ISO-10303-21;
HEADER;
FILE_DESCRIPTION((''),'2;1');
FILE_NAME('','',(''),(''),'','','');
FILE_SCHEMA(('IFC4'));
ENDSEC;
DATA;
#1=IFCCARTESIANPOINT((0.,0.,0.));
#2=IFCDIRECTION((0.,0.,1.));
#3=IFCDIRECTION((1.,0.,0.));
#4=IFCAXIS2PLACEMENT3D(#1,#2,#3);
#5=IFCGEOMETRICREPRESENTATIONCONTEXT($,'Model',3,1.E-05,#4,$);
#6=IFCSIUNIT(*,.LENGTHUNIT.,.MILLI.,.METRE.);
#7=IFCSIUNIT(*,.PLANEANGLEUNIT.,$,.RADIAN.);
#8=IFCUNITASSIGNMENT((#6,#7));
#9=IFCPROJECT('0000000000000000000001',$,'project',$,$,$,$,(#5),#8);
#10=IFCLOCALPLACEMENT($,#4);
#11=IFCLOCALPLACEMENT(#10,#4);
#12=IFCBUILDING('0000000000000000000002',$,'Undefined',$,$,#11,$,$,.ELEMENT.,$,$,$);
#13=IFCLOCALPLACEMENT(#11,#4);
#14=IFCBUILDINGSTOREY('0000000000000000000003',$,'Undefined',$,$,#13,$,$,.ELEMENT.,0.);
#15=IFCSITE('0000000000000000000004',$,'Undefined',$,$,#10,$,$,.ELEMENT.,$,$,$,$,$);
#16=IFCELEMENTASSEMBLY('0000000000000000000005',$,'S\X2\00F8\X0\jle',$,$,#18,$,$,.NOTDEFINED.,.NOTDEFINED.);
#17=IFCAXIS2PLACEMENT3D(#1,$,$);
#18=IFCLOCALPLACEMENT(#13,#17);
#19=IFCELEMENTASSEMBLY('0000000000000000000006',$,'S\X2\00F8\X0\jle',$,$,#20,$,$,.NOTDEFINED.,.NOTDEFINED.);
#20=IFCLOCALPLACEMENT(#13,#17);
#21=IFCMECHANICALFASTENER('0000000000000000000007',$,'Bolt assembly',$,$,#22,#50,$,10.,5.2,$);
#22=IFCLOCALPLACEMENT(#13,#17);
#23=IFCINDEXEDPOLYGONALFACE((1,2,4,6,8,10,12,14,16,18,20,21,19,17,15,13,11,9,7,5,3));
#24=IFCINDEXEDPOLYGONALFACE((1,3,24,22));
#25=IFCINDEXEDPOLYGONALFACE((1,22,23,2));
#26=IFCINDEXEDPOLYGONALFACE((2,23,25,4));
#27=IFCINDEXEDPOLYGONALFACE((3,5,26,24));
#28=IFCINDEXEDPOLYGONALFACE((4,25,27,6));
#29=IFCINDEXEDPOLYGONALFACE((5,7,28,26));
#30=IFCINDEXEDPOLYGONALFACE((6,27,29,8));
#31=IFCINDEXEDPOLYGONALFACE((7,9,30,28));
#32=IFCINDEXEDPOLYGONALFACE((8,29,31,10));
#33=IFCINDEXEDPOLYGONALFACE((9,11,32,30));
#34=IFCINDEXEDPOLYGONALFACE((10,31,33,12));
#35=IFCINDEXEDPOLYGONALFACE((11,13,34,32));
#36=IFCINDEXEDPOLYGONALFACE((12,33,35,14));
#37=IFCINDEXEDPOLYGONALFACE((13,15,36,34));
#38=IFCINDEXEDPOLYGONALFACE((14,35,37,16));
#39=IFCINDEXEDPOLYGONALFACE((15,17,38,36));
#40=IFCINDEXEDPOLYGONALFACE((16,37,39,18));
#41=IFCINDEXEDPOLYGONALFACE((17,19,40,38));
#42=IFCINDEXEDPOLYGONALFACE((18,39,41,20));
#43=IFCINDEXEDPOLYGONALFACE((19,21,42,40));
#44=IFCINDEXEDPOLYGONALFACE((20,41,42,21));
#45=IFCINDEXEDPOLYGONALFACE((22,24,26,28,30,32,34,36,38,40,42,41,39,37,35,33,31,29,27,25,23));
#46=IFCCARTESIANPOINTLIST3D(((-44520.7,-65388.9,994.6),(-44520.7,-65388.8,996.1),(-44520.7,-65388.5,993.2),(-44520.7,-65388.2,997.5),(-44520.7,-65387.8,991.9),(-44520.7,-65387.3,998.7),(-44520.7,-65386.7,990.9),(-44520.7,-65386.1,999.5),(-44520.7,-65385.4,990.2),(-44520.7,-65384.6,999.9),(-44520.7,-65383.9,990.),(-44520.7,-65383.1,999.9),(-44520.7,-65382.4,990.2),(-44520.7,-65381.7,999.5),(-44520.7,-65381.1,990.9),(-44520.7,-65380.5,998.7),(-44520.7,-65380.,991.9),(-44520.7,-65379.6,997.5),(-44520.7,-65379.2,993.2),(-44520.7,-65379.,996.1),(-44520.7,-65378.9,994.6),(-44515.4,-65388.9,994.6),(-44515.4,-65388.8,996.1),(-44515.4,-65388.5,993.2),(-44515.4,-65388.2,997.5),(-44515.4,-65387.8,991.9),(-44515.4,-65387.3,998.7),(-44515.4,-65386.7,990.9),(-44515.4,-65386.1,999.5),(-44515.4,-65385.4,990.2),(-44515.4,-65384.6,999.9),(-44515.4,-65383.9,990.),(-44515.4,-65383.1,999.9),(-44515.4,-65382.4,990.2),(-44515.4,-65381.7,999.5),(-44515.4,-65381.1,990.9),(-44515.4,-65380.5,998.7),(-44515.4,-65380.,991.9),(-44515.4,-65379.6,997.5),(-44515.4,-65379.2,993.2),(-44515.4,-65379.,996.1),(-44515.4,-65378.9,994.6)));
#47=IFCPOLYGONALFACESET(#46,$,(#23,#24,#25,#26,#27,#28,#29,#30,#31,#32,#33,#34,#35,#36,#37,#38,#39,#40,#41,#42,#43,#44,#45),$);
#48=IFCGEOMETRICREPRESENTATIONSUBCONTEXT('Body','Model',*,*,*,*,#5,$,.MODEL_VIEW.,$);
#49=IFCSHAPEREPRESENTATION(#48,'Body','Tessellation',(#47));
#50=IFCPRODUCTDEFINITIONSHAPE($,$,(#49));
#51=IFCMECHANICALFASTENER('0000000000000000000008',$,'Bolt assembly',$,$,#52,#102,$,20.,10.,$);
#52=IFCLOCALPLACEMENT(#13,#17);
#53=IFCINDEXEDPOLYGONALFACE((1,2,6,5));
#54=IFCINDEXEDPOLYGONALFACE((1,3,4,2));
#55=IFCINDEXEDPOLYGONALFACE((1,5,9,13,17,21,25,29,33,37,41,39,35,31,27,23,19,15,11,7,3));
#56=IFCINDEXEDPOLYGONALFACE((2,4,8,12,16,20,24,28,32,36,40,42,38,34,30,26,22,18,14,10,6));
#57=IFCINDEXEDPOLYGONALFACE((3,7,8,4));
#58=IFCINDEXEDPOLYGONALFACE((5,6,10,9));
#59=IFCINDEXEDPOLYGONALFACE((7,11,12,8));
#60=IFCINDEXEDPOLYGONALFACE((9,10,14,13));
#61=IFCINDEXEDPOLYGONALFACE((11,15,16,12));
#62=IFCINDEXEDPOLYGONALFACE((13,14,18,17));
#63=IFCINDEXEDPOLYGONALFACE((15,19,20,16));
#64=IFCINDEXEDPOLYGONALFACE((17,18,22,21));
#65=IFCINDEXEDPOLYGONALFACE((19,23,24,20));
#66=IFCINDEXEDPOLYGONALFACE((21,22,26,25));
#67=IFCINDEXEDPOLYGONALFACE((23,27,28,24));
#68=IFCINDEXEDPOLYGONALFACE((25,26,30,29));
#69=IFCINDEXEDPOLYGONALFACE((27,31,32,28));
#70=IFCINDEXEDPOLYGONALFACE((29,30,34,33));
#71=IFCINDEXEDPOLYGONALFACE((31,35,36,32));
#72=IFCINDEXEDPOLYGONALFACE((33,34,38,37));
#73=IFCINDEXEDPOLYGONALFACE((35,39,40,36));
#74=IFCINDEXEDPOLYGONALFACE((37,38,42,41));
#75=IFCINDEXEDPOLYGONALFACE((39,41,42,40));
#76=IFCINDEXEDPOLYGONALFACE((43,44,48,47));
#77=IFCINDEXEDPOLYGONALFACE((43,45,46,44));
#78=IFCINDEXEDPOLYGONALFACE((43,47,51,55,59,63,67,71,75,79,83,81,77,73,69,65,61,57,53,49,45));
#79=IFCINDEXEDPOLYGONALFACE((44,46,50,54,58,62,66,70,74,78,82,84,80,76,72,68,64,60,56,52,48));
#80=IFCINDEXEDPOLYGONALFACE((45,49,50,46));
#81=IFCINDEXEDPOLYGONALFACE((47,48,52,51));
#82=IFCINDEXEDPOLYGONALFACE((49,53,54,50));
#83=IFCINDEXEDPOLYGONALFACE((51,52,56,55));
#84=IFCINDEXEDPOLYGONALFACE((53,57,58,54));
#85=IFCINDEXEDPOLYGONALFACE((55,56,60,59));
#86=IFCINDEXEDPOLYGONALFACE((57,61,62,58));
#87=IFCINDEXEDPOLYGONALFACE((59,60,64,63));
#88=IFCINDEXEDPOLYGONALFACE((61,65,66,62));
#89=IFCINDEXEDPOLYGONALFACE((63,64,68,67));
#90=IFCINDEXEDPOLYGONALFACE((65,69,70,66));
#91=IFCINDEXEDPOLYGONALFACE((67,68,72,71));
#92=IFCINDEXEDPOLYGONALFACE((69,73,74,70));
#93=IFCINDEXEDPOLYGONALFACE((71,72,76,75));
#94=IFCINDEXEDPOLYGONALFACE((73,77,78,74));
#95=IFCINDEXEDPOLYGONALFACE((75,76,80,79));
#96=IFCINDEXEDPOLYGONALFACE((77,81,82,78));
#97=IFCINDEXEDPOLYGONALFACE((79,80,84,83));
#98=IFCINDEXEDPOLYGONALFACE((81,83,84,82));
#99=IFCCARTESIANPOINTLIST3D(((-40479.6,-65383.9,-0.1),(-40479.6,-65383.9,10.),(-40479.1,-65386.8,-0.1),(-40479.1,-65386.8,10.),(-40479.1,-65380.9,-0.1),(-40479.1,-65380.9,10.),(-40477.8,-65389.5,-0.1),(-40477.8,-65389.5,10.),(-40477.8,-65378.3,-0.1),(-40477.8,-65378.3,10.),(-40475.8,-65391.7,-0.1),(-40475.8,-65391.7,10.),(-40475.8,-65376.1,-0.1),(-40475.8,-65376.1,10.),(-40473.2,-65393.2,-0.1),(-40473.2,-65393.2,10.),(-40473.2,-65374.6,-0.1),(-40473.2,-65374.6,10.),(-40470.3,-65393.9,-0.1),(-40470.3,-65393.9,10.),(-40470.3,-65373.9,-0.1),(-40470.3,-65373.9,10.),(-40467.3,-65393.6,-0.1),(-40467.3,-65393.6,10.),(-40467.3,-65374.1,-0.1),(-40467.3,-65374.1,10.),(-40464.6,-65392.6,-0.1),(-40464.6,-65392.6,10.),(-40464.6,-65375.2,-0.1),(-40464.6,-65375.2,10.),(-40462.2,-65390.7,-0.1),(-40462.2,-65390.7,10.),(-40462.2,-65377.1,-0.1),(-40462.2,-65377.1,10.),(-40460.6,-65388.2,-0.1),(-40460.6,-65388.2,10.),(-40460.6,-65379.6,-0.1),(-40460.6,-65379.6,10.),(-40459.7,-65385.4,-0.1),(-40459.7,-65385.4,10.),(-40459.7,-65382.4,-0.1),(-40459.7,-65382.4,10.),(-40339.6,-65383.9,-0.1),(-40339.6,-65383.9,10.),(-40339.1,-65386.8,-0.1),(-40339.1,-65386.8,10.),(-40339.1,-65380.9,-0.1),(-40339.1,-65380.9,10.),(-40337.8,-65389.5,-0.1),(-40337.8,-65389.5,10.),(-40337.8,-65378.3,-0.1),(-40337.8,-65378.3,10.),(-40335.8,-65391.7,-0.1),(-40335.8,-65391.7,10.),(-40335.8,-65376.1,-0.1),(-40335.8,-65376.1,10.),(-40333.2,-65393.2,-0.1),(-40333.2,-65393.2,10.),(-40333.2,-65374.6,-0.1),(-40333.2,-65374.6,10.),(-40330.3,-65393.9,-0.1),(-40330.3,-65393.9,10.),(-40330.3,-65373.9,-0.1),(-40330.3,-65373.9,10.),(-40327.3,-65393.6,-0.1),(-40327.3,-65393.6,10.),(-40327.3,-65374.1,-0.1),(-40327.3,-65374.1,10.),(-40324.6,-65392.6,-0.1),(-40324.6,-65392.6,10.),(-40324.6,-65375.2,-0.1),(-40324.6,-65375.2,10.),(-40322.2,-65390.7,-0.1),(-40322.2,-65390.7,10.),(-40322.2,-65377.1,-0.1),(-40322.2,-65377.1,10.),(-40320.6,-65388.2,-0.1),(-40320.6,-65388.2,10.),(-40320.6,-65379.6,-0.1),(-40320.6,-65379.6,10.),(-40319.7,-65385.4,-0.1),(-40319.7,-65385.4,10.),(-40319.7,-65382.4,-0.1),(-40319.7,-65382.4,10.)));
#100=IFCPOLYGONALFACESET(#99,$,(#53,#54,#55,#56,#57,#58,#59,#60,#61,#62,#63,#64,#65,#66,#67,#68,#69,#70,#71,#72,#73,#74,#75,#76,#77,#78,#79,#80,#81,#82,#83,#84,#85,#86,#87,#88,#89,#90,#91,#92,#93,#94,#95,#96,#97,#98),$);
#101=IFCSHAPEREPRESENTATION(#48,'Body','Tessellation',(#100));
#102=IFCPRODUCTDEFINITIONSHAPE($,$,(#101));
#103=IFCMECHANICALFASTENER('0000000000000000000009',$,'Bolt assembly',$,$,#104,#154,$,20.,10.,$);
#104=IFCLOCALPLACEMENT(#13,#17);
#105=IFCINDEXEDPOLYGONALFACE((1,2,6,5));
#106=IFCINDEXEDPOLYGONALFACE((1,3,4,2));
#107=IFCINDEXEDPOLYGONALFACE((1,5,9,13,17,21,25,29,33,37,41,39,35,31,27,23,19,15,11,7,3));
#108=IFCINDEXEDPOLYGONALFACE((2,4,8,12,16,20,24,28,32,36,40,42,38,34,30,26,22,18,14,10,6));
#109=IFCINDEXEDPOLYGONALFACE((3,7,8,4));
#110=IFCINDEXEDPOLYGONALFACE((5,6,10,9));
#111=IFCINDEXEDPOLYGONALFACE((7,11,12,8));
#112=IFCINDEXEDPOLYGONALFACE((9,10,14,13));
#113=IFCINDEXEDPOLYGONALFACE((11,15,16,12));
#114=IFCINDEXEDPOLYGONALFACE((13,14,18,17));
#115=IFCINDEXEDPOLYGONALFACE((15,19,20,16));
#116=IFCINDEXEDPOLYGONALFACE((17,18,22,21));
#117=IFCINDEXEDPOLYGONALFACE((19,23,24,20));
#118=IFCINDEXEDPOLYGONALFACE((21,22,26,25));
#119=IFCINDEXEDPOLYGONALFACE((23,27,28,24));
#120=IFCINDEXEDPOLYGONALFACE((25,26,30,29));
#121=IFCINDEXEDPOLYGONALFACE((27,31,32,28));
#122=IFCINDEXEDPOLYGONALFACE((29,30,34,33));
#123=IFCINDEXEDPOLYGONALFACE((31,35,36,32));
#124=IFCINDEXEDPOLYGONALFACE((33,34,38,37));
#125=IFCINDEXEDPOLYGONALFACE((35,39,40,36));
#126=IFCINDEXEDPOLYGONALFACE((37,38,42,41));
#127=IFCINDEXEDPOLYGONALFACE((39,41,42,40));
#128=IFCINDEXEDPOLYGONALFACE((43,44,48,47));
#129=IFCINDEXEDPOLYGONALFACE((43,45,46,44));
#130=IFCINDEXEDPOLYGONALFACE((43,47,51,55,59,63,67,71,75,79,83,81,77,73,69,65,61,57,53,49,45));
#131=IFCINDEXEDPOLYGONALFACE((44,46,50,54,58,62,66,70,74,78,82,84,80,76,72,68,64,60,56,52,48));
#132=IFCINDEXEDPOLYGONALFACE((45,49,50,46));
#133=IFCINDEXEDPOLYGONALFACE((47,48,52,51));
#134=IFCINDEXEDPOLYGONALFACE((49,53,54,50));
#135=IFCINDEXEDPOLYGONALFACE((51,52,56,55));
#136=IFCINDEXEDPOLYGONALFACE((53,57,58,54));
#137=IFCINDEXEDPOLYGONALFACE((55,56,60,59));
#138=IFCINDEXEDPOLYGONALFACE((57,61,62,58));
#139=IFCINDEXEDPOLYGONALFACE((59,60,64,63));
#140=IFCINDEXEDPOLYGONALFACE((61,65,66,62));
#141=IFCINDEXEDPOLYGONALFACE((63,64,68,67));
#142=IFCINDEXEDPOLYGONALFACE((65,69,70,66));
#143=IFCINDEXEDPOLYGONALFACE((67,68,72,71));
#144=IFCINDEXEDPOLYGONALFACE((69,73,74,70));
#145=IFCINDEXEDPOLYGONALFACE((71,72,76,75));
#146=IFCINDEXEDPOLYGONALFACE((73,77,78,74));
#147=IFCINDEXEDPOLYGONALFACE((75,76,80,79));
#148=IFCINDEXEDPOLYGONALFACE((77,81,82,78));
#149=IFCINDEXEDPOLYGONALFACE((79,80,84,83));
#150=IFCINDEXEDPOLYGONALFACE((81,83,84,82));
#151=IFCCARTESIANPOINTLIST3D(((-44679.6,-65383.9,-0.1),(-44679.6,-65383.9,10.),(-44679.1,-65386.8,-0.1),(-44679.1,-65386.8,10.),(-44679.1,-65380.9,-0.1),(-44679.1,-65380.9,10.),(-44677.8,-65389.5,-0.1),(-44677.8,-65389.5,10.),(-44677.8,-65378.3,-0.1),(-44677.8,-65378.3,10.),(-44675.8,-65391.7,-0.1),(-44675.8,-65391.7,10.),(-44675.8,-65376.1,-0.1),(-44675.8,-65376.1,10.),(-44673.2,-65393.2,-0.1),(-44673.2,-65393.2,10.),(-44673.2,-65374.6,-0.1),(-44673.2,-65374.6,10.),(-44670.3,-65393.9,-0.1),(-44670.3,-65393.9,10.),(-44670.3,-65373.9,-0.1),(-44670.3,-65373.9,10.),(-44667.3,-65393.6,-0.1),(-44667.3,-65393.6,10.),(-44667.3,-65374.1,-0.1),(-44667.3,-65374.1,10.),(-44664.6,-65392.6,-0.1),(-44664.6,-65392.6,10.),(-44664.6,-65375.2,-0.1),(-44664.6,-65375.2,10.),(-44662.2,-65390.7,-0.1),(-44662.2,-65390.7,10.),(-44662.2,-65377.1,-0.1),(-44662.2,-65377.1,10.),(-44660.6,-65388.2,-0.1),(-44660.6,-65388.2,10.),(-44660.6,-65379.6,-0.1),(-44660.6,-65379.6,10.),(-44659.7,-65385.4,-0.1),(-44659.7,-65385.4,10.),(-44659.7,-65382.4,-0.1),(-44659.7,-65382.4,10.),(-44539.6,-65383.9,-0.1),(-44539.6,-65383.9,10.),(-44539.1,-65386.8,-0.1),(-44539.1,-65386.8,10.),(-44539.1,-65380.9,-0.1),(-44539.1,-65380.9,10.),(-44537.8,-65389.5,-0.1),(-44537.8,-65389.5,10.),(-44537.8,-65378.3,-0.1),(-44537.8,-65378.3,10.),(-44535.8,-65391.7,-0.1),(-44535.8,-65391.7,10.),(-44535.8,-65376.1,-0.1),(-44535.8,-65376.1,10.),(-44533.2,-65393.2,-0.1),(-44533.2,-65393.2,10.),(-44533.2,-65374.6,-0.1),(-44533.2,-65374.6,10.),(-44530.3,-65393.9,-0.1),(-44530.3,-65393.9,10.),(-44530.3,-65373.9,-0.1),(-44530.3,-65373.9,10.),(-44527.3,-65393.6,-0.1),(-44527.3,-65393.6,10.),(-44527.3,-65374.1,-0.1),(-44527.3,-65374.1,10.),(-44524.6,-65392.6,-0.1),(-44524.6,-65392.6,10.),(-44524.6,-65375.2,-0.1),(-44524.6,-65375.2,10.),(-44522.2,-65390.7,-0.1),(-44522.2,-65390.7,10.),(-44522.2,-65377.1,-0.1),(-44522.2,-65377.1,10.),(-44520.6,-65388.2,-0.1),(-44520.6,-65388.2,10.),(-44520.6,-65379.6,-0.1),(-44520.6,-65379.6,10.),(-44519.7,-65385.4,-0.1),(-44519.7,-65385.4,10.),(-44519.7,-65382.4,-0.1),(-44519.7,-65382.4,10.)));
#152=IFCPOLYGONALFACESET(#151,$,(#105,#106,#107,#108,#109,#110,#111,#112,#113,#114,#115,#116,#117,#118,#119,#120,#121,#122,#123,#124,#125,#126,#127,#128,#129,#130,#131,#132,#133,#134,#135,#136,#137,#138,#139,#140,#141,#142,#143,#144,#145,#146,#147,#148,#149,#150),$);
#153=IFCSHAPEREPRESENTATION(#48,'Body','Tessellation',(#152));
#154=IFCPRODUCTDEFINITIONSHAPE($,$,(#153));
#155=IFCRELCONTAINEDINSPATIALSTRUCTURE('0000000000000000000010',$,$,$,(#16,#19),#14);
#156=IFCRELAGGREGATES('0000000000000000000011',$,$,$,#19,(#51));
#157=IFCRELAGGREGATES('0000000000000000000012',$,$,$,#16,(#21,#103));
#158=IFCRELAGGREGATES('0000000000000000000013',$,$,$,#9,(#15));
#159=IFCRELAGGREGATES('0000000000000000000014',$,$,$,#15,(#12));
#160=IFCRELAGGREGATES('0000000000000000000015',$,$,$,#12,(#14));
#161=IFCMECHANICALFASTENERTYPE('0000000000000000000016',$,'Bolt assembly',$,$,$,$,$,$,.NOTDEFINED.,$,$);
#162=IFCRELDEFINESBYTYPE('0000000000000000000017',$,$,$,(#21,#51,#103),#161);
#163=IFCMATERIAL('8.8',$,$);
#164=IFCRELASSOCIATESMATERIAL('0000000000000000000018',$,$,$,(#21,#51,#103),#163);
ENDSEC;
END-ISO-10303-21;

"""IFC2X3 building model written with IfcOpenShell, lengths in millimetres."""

from ifc_helpers import new_model, si_unit, frame, origin_with_axes, origin_2d_with_axis, place, context, subcontext, project, spatial, circle, extrude, source, transform, mapped, material, type_object, element, aggregate, save


model = new_model("IFC2X3")

# Units and contexts
model_context = context("Model", 3, precision=1e-05, world=origin_with_axes())
body_context = subcontext(model_context, "Body", "Model", "MODEL_VIEW")
ifc_project = project(units=[si_unit("LENGTHUNIT", "METRE", prefix="MILLI"), si_unit("PLANEANGLEUNIT", "RADIAN")], contexts=[model_context])

# Site, building, storey
site_placement = place(None, origin_with_axes())
site = spatial("IfcSite", under=ifc_project, at=site_placement, Name="Undefined", CompositionType="ELEMENT")
building_placement = place(site_placement, origin_with_axes())
building = spatial("IfcBuilding", under=site, at=building_placement, Name="Undefined", CompositionType="ELEMENT")
storey_placement = place(building_placement, origin_with_axes())
storey = spatial("IfcBuildingStorey", under=building, at=storey_placement, Name="Undefined", CompositionType="ELEMENT", Elevation=0.0)

# Element assembly
assembly_1_placement = place(storey_placement, origin_with_axes())
assembly_1 = element("IfcElementAssembly", 1, at=assembly_1_placement, inside=storey, Name="Søjle", AssemblyPlace="NOTDEFINED", PredefinedType="NOTDEFINED")

# Element assembly
assembly_2_placement = place(storey_placement, origin_with_axes())
assembly_2 = element("IfcElementAssembly", 2, at=assembly_2_placement, inside=storey, Name="Søjle", AssemblyPlace="NOTDEFINED", PredefinedType="NOTDEFINED")

# Shared definitions
ifc_material_1 = material(Name="8.8")
mechanical_fastener_type = type_object("IfcMechanicalFastenerType", Name="Bolt assembly")

# Mechanical fasteners
shared_shape_1 = source(origin_with_axes(), body_context, "Body", "SweptSolid", [
    extrude(circle(Radius=5.0, at=origin_2d_with_axis()), frame((0.0, 0.0, 0.0), z_axis=(0.0, 1.0, 0.0), x_axis=(1.0, 0.0, 0.0)), (0.0, 0.0, 1.0), 5.3),
])
mechanical_fastener_1_placement = place(assembly_1_placement, frame((-44515.4, -65383.9, 995.0), z_axis=(0.0, 1.0, 0.0), x_axis=(0.0, 0.0, -1.0)))
mechanical_fastener_1 = element("IfcMechanicalFastener", 3, at=mechanical_fastener_1_placement, type_object=mechanical_fastener_type, material=ifc_material_1, Name="Bolt assembly", NominalDiameter=10.0, NominalLength=5.2, context=body_context, shape_type="MappedRepresentation", body=[
    mapped(shared_shape_1, transform((0.0, 0.0, 0.0))),
])
shared_shape_2 = source(origin_with_axes(), body_context, "Body", "SweptSolid", [
    extrude(circle(Radius=10.0, at=origin_2d_with_axis()), frame((0.0, -10.0, 0.0), z_axis=(0.0, 1.0, 0.0), x_axis=(1.0, 0.0, 0.0)), (0.0, 0.0, 1.0), 10.1),
])
mechanical_fastener_2_placement = place(assembly_2_placement, frame((-40329.6, -65383.9, 0.0), z_axis=(0.0, -1.0, 0.0), x_axis=(-1.0, 0.0, 0.0)))
mechanical_fastener_2 = element("IfcMechanicalFastener", 4, at=mechanical_fastener_2_placement, type_object=mechanical_fastener_type, material=ifc_material_1, Name="Bolt assembly", NominalDiameter=20.0, NominalLength=10.0, context=body_context, shape_type="MappedRepresentation", body=[
    mapped(shared_shape_2, transform((0.0, 0.0, 0.0))),
    mapped(shared_shape_2, transform((140.0, 0.0, 0.0))),
])
aggregate(assembly_2, [mechanical_fastener_2])
mechanical_fastener_3_placement = place(assembly_1_placement, frame((-44529.6, -65383.9, 0.0), z_axis=(0.0, -1.0, 0.0), x_axis=(-1.0, 0.0, 0.0)))
mechanical_fastener_3 = element("IfcMechanicalFastener", 5, at=mechanical_fastener_3_placement, type_object=mechanical_fastener_type, material=ifc_material_1, Name="Bolt assembly", NominalDiameter=20.0, NominalLength=10.0, context=body_context, shape_type="MappedRepresentation", body=[
    mapped(shared_shape_2, transform((0.0, 0.0, 0.0))),
    mapped(shared_shape_2, transform((140.0, 0.0, 0.0))),
])
aggregate(assembly_1, [mechanical_fastener_1, mechanical_fastener_3])

save(model, "model.ifc")
